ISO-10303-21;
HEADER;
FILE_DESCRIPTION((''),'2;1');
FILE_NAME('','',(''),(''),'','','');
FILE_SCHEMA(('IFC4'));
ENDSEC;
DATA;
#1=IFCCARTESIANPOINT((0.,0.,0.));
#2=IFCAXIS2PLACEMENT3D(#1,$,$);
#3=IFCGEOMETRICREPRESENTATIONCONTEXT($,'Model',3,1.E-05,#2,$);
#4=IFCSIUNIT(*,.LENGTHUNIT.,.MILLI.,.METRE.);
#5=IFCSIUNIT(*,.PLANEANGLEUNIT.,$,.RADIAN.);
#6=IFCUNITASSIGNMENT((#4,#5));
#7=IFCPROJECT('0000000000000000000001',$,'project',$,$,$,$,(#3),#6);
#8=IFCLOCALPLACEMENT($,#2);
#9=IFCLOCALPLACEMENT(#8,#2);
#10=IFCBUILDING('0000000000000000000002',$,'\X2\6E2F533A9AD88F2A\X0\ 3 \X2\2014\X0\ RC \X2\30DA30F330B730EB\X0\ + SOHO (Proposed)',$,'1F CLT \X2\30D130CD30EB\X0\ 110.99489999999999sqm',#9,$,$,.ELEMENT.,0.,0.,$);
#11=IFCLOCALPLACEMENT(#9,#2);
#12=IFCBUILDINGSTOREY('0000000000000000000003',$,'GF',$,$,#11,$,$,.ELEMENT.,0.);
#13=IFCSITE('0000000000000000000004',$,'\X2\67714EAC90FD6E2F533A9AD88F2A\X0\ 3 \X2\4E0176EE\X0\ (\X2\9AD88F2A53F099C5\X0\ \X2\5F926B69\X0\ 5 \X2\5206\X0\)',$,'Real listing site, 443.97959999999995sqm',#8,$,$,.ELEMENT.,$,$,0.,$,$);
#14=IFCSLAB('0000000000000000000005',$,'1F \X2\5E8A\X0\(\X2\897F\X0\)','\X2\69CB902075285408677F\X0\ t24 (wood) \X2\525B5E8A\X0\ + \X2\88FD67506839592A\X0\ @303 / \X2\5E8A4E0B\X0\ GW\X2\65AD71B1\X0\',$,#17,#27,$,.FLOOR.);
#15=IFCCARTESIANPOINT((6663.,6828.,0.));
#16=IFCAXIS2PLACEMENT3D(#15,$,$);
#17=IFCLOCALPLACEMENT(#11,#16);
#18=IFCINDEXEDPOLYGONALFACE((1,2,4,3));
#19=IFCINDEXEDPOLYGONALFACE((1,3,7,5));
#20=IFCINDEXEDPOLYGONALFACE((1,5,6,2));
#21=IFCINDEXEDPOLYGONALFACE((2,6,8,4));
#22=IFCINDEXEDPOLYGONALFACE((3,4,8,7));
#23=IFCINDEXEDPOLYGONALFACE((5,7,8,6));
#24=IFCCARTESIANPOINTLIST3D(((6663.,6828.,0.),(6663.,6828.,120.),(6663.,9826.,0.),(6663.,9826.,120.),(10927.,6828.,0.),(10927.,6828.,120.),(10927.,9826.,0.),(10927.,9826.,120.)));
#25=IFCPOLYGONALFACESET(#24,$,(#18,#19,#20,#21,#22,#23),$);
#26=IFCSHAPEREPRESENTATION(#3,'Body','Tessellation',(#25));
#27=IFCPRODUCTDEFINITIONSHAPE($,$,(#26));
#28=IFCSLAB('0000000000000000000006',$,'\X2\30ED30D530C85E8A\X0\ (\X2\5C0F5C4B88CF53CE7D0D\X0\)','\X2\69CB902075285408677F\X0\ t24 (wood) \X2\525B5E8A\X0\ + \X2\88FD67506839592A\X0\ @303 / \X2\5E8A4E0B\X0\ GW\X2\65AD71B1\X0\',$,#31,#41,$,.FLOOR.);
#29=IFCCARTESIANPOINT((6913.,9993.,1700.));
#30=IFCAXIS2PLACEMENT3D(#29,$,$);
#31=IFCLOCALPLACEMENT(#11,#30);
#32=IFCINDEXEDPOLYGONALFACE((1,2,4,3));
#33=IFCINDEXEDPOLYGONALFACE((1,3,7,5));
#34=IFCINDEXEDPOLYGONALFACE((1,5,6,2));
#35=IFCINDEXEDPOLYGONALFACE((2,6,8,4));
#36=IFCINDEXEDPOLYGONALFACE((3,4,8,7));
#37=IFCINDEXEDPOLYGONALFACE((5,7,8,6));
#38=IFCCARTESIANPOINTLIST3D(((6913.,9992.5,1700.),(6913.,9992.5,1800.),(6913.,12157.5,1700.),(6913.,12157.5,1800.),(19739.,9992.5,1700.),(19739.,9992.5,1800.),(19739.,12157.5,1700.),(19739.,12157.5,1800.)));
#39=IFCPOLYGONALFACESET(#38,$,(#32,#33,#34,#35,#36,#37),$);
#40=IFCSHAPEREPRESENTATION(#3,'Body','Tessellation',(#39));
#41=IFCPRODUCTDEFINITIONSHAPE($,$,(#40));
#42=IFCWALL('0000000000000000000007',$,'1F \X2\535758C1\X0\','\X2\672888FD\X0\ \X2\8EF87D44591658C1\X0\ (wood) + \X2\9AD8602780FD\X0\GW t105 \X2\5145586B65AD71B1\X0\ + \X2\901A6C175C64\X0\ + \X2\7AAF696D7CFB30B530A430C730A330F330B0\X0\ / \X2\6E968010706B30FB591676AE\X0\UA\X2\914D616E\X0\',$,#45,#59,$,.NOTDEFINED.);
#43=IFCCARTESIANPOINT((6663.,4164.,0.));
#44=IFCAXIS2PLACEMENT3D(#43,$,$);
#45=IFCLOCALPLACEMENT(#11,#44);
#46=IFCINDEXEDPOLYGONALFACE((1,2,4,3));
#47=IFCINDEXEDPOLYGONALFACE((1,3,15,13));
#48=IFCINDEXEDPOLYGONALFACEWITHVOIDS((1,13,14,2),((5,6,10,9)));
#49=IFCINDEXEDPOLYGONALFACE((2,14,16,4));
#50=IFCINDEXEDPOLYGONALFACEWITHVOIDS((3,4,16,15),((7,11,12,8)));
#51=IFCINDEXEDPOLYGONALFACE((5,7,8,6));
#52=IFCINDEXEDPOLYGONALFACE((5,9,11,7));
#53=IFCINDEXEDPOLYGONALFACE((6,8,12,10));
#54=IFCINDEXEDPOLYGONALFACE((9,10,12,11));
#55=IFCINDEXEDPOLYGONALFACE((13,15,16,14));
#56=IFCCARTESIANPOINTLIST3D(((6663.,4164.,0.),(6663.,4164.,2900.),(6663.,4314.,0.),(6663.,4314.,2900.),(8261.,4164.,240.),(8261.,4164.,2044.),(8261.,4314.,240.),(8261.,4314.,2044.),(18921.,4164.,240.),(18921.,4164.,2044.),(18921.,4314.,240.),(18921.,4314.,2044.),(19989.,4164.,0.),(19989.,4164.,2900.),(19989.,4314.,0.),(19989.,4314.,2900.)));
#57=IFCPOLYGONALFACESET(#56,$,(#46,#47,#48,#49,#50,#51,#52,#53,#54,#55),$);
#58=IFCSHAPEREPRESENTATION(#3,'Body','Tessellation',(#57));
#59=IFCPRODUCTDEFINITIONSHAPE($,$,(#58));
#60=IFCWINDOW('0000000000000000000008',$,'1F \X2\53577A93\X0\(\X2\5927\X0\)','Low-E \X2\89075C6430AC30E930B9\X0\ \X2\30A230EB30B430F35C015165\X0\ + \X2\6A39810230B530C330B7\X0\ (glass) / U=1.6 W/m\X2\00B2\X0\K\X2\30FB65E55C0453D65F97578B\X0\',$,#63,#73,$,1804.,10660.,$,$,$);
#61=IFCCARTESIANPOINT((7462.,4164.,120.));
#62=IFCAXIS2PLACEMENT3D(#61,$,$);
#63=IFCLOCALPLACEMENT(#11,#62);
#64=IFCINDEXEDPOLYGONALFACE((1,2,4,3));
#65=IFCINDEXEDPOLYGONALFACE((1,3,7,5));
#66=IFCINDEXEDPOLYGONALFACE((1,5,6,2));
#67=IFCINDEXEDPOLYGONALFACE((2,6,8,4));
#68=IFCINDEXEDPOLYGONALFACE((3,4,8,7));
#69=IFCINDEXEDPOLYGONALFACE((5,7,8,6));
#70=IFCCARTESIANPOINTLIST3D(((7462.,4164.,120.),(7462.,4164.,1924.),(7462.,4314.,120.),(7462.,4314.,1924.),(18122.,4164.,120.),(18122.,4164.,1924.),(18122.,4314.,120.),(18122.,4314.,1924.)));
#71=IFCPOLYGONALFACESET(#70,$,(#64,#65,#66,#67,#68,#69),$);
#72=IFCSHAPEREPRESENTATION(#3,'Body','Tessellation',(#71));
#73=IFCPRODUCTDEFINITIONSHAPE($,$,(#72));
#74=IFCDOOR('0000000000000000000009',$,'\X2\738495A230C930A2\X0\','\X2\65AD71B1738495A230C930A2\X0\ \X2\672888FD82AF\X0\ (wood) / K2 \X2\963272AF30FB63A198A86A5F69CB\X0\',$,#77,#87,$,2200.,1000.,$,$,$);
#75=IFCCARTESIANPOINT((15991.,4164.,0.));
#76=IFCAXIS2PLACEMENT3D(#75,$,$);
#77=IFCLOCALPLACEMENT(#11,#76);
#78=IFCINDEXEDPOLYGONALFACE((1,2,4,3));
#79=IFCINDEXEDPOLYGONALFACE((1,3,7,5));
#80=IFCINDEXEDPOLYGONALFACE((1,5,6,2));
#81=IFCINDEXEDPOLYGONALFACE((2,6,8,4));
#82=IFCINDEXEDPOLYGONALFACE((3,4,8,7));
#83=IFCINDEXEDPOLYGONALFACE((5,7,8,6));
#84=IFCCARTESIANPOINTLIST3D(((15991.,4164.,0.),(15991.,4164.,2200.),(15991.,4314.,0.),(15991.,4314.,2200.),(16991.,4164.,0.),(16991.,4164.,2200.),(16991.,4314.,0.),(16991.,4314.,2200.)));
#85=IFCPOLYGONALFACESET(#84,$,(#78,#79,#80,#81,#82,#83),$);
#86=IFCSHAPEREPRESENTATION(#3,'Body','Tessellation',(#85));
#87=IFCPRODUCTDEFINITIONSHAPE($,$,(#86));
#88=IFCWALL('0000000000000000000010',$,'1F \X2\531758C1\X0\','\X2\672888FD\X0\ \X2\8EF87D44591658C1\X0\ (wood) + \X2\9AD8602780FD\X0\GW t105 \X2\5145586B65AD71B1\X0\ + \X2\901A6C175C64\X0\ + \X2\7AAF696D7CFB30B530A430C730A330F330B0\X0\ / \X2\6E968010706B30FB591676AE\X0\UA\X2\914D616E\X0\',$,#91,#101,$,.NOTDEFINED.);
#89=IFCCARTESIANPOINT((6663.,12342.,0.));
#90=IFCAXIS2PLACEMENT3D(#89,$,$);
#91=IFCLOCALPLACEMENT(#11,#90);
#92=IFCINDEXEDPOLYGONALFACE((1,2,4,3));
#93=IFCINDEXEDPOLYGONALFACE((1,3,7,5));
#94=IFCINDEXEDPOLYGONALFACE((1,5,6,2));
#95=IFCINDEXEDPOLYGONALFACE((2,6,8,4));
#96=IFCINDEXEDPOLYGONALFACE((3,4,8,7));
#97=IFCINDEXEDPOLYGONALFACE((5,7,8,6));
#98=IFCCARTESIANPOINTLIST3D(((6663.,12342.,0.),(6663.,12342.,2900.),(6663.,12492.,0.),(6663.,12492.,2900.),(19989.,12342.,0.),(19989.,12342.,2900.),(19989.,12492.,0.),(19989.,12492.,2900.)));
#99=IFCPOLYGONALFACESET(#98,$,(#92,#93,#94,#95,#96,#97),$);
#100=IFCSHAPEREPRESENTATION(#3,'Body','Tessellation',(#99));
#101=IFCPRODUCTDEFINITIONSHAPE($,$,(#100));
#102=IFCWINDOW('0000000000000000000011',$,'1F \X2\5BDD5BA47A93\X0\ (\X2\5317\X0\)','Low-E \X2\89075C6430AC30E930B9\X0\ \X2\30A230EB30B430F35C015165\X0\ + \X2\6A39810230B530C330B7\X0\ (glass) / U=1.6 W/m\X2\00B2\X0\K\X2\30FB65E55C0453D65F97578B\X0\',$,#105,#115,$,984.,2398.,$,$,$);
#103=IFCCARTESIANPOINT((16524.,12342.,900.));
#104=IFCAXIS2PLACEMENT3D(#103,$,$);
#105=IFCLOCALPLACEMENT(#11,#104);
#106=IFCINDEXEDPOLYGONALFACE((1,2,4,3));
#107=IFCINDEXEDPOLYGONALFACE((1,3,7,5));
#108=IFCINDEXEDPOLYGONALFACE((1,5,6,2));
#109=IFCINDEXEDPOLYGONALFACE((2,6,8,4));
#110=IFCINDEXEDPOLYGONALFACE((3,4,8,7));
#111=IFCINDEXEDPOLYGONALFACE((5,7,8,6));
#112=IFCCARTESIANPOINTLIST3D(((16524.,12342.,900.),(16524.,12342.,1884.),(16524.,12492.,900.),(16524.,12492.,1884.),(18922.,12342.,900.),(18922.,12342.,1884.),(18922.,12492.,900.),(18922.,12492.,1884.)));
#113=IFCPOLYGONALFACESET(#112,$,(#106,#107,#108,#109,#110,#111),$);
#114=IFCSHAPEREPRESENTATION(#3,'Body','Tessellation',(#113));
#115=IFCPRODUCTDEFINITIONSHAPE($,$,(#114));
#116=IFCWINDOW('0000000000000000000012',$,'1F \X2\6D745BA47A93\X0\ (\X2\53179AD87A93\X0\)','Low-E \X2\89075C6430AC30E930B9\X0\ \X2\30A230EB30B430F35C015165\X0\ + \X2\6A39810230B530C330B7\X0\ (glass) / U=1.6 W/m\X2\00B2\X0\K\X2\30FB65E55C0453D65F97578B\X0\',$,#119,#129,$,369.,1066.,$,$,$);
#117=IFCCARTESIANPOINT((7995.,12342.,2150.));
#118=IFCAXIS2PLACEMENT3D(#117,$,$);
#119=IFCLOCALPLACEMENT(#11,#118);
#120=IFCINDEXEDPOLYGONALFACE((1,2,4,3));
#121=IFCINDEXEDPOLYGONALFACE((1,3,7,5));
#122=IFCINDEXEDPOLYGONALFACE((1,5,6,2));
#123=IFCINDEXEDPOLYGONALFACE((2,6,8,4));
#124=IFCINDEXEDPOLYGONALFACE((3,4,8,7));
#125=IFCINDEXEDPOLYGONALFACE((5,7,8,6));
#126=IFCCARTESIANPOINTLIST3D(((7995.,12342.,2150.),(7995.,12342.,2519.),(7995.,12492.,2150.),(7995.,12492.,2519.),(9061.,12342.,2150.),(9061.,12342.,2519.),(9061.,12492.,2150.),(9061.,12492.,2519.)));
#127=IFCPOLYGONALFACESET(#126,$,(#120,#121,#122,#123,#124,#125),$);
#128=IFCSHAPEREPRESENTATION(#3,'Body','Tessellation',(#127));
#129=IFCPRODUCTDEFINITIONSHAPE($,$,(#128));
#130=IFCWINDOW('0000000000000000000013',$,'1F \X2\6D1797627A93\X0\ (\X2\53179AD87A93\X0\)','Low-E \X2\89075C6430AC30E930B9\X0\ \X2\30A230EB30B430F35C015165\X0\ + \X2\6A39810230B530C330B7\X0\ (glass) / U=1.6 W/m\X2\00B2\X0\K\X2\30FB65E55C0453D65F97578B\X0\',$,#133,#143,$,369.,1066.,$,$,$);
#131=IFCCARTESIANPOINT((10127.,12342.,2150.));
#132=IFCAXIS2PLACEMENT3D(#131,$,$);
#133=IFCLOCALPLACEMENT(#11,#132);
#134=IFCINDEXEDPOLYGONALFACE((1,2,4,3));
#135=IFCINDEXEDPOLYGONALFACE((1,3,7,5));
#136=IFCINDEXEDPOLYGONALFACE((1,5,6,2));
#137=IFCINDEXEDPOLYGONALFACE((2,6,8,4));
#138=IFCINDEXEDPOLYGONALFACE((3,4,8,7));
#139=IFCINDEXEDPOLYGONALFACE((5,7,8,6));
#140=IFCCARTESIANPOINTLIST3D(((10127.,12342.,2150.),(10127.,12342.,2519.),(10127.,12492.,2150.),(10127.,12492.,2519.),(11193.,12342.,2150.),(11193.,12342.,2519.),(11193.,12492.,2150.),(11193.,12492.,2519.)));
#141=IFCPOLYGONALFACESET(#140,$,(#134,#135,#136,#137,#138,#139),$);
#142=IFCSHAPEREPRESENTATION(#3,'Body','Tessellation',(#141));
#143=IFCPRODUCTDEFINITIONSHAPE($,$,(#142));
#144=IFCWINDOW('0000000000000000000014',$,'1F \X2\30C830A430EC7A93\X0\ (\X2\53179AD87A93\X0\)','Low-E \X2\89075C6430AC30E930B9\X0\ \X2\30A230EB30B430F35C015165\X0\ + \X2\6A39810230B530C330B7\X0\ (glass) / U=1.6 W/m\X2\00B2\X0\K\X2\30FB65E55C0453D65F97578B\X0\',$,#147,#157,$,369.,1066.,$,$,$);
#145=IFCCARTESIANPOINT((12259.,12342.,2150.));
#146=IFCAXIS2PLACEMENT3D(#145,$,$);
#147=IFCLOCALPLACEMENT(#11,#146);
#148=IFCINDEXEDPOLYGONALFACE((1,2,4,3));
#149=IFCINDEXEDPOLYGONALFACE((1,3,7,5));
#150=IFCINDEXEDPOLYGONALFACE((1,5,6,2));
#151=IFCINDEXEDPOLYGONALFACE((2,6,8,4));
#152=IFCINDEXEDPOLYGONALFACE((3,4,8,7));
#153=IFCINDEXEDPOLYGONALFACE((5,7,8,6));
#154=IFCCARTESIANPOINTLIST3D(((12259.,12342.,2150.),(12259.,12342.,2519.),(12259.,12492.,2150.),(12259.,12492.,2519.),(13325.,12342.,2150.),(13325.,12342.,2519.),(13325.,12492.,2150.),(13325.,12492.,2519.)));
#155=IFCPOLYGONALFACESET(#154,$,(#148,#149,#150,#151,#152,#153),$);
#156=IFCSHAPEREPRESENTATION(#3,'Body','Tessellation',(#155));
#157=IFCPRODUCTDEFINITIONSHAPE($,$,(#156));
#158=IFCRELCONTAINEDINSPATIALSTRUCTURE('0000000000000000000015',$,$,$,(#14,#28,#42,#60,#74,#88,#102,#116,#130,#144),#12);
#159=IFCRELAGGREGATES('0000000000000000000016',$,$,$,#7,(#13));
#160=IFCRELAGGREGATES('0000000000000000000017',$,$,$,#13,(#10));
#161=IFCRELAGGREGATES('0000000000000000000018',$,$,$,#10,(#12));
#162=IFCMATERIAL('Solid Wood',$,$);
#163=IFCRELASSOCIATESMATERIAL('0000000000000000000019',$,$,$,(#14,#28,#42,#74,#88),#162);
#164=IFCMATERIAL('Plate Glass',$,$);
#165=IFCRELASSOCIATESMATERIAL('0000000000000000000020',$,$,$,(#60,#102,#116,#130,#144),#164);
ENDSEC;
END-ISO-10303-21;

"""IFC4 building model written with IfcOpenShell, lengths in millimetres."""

from ifc_helpers import new_model, si_unit, frame, frame_2d, origin, place, context, project, spatial, rectangle, extrude, material, element, fill, save


model = new_model("IFC4")

# Units and contexts
model_context = context("Model", 3, precision=1e-05, world=origin())
ifc_project = project(units=[si_unit("LENGTHUNIT", "METRE", prefix="MILLI"), si_unit("PLANEANGLEUNIT", "RADIAN")], contexts=[model_context])

# Site, building, storey
site_placement = place(None, origin())
site = spatial("IfcSite", under=ifc_project, at=site_placement, Name="東京都港区高輪 3 丁目 (高輪台駅 徒歩 5 分)", ObjectType="Real listing site, 443.97959999999995sqm", CompositionType="ELEMENT", RefElevation=0.0)
building_placement = place(site_placement, origin())
building = spatial("IfcBuilding", under=site, at=building_placement, Name="港区高輪 3 — RC ペンシル + SOHO (Proposed)", ObjectType="1F CLT パネル 110.99489999999999sqm", CompositionType="ELEMENT", ElevationOfRefHeight=0.0, ElevationOfTerrain=0.0)
storey_placement = place(building_placement, origin())
storey = spatial("IfcBuildingStorey", under=building, at=storey_placement, Name="GF", CompositionType="ELEMENT", Elevation=0.0)

# Slabs
ifc_material_1 = material(Name="Solid Wood")
slab_1_placement = place(storey_placement, frame((6663.0, 6828.0, 0.0)))
element("IfcSlab", 1, at=slab_1_placement, inside=storey, material=ifc_material_1, Name="1F 床(西)", Description="構造用合板 t24 (wood) 剛床 + 製材根太 @303 / 床下 GW断熱", PredefinedType="FLOOR", context=model_context, shape_type="SweptSolid", body=[
    extrude(rectangle(XDim=4264.0, YDim=2998.0, at=frame_2d((2132.0, 1499.0))), frame((6663.0, 6828.0, 0.0)), (0.0, 0.0, 1.0), 120.0),
])
slab_2_placement = place(storey_placement, frame((6913.0, 9993.0, 1700.0)))
element("IfcSlab", 2, at=slab_2_placement, inside=storey, material=ifc_material_1, Name="ロフト床 (小屋裏収納)", Description="構造用合板 t24 (wood) 剛床 + 製材根太 @303 / 床下 GW断熱", PredefinedType="FLOOR", context=model_context, shape_type="SweptSolid", body=[
    extrude(rectangle(XDim=12826.0, YDim=2165.0, at=frame_2d((6413.0, 1082.0))), frame((6913.0, 9993.0, 1700.0)), (0.0, 0.0, 1.0), 100.0),
])

# Wall, openings, window, door
wall_1_placement = place(storey_placement, frame((6663.0, 4164.0, 0.0)))
wall_1 = element("IfcWall", 3, at=wall_1_placement, inside=storey, material=ifc_material_1, Name="1F 南壁", Description="木製 軸組外壁 (wood) + 高性能GW t105 充填断熱 + 通気層 + 窯業系サイディング / 準耐火・外皮UA配慮", PredefinedType="NOTDEFINED", context=model_context, shape_type="SweptSolid", body=[
    extrude(rectangle(XDim=13326.0, YDim=150.0, at=frame_2d((6663.0, 75.0))), frame((6663.0, 4164.0, 0.0)), (0.0, 0.0, 1.0), 2900.0),
])
opening_1_placement = place(storey_placement, frame((7462.0, 4164.0, 120.0)))
opening_1 = element("IfcOpeningElement", 4, at=opening_1_placement, cuts=wall_1, PredefinedType="NOTDEFINED", context=model_context, shape_type="SweptSolid", body=[
    extrude(rectangle(XDim=10660.0, YDim=150.0, at=frame_2d((5330.0, 75.0))), frame((7462.0, 4164.0, 120.0)), (0.0, 0.0, 1.0), 1804.0),
])
opening_2_placement = place(storey_placement, frame((15991.0, 4164.0, 0.0)))
opening_2 = element("IfcOpeningElement", 5, at=opening_2_placement, cuts=wall_1, PredefinedType="NOTDEFINED", context=model_context, shape_type="SweptSolid", body=[
    extrude(rectangle(XDim=1000.0, YDim=150.0, at=frame_2d((500.0, 75.0))), frame((15991.0, 4164.0, 0.0)), (0.0, 0.0, 1.0), 2200.0),
])
ifc_material_2 = material(Name="Plate Glass")
window_1_placement = place(storey_placement, frame((7462.0, 4164.0, 120.0)))
window_1 = element("IfcWindow", 6, at=window_1_placement, inside=storey, material=ifc_material_2, Name="1F 南窓(大)", Description="Low-E 複層ガラス アルゴン封入 + 樹脂サッシ (glass) / U=1.6 W/m²K・日射取得型", OverallHeight=1804.0, OverallWidth=10660.0, context=model_context, shape_type="SweptSolid", body=[
    extrude(rectangle(XDim=10660.0, YDim=150.0, at=frame_2d((5330.0, 75.0))), frame((7462.0, 4164.0, 120.0)), (0.0, 0.0, 1.0), 1804.0),
])
fill(opening_1, window_1)
door_1_placement = place(storey_placement, frame((15991.0, 4164.0, 0.0)))
door_1 = element("IfcDoor", 7, at=door_1_placement, inside=storey, material=ifc_material_1, Name="玄関ドア", Description="断熱玄関ドア 木製芯 (wood) / K2 防犯・採風機構", OverallHeight=2200.0, OverallWidth=1000.0, context=model_context, shape_type="SweptSolid", body=[
    extrude(rectangle(XDim=1000.0, YDim=150.0, at=frame_2d((500.0, 75.0))), frame((15991.0, 4164.0, 0.0)), (0.0, 0.0, 1.0), 2200.0),
])
fill(opening_2, door_1)

# Wall, openings, windows
wall_2_placement = place(storey_placement, frame((6663.0, 12342.0, 0.0)))
wall_2 = element("IfcWall", 8, at=wall_2_placement, inside=storey, material=ifc_material_1, Name="1F 北壁", Description="木製 軸組外壁 (wood) + 高性能GW t105 充填断熱 + 通気層 + 窯業系サイディング / 準耐火・外皮UA配慮", PredefinedType="NOTDEFINED", context=model_context, shape_type="SweptSolid", body=[
    extrude(rectangle(XDim=13326.0, YDim=150.0, at=frame_2d((6663.0, 75.0))), frame((6663.0, 12342.0, 0.0)), (0.0, 0.0, 1.0), 2900.0),
])
opening_3_placement = place(storey_placement, frame((16524.0, 12342.0, 900.0)))
opening_3 = element("IfcOpeningElement", 9, at=opening_3_placement, cuts=wall_2, PredefinedType="NOTDEFINED", context=model_context, shape_type="SweptSolid", body=[
    extrude(rectangle(XDim=2398.0, YDim=150.0, at=frame_2d((1199.0, 75.0))), frame((16524.0, 12342.0, 900.0)), (0.0, 0.0, 1.0), 984.0),
])
opening_4_placement = place(storey_placement, frame((7995.0, 12342.0, 2150.0)))
opening_4 = element("IfcOpeningElement", 10, at=opening_4_placement, cuts=wall_2, PredefinedType="NOTDEFINED", context=model_context, shape_type="SweptSolid", body=[
    extrude(rectangle(XDim=1066.0, YDim=150.0, at=frame_2d((533.0, 75.0))), frame((7995.0, 12342.0, 2150.0)), (0.0, 0.0, 1.0), 369.0),
])
opening_5_placement = place(storey_placement, frame((10127.0, 12342.0, 2150.0)))
opening_5 = element("IfcOpeningElement", 11, at=opening_5_placement, cuts=wall_2, PredefinedType="NOTDEFINED", context=model_context, shape_type="SweptSolid", body=[
    extrude(rectangle(XDim=1066.0, YDim=150.0, at=frame_2d((533.0, 75.0))), frame((10127.0, 12342.0, 2150.0)), (0.0, 0.0, 1.0), 369.0),
])
opening_6_placement = place(storey_placement, frame((12259.0, 12342.0, 2150.0)))
opening_6 = element("IfcOpeningElement", 12, at=opening_6_placement, cuts=wall_2, PredefinedType="NOTDEFINED", context=model_context, shape_type="SweptSolid", body=[
    extrude(rectangle(XDim=1066.0, YDim=150.0, at=frame_2d((533.0, 75.0))), frame((12259.0, 12342.0, 2150.0)), (0.0, 0.0, 1.0), 369.0),
])
window_2_placement = place(storey_placement, frame((16524.0, 12342.0, 900.0)))
window_2 = element("IfcWindow", 13, at=window_2_placement, inside=storey, material=ifc_material_2, Name="1F 寝室窓 (北)", Description="Low-E 複層ガラス アルゴン封入 + 樹脂サッシ (glass) / U=1.6 W/m²K・日射取得型", OverallHeight=984.0, OverallWidth=2398.0, context=model_context, shape_type="SweptSolid", body=[
    extrude(rectangle(XDim=2398.0, YDim=150.0, at=frame_2d((1199.0, 75.0))), frame((16524.0, 12342.0, 900.0)), (0.0, 0.0, 1.0), 984.0),
])
fill(opening_3, window_2)
window_3_placement = place(storey_placement, frame((7995.0, 12342.0, 2150.0)))
window_3 = element("IfcWindow", 14, at=window_3_placement, inside=storey, material=ifc_material_2, Name="1F 浴室窓 (北高窓)", Description="Low-E 複層ガラス アルゴン封入 + 樹脂サッシ (glass) / U=1.6 W/m²K・日射取得型", OverallHeight=369.0, OverallWidth=1066.0, context=model_context, shape_type="SweptSolid", body=[
    extrude(rectangle(XDim=1066.0, YDim=150.0, at=frame_2d((533.0, 75.0))), frame((7995.0, 12342.0, 2150.0)), (0.0, 0.0, 1.0), 369.0),
])
fill(opening_4, window_3)
window_4_placement = place(storey_placement, frame((10127.0, 12342.0, 2150.0)))
window_4 = element("IfcWindow", 15, at=window_4_placement, inside=storey, material=ifc_material_2, Name="1F 洗面窓 (北高窓)", Description="Low-E 複層ガラス アルゴン封入 + 樹脂サッシ (glass) / U=1.6 W/m²K・日射取得型", OverallHeight=369.0, OverallWidth=1066.0, context=model_context, shape_type="SweptSolid", body=[
    extrude(rectangle(XDim=1066.0, YDim=150.0, at=frame_2d((533.0, 75.0))), frame((10127.0, 12342.0, 2150.0)), (0.0, 0.0, 1.0), 369.0),
])
fill(opening_5, window_4)
window_5_placement = place(storey_placement, frame((12259.0, 12342.0, 2150.0)))
window_5 = element("IfcWindow", 16, at=window_5_placement, inside=storey, material=ifc_material_2, Name="1F トイレ窓 (北高窓)", Description="Low-E 複層ガラス アルゴン封入 + 樹脂サッシ (glass) / U=1.6 W/m²K・日射取得型", OverallHeight=369.0, OverallWidth=1066.0, context=model_context, shape_type="SweptSolid", body=[
    extrude(rectangle(XDim=1066.0, YDim=150.0, at=frame_2d((533.0, 75.0))), frame((12259.0, 12342.0, 2150.0)), (0.0, 0.0, 1.0), 369.0),
])
fill(opening_6, window_5)

save(model, "model.ifc")
